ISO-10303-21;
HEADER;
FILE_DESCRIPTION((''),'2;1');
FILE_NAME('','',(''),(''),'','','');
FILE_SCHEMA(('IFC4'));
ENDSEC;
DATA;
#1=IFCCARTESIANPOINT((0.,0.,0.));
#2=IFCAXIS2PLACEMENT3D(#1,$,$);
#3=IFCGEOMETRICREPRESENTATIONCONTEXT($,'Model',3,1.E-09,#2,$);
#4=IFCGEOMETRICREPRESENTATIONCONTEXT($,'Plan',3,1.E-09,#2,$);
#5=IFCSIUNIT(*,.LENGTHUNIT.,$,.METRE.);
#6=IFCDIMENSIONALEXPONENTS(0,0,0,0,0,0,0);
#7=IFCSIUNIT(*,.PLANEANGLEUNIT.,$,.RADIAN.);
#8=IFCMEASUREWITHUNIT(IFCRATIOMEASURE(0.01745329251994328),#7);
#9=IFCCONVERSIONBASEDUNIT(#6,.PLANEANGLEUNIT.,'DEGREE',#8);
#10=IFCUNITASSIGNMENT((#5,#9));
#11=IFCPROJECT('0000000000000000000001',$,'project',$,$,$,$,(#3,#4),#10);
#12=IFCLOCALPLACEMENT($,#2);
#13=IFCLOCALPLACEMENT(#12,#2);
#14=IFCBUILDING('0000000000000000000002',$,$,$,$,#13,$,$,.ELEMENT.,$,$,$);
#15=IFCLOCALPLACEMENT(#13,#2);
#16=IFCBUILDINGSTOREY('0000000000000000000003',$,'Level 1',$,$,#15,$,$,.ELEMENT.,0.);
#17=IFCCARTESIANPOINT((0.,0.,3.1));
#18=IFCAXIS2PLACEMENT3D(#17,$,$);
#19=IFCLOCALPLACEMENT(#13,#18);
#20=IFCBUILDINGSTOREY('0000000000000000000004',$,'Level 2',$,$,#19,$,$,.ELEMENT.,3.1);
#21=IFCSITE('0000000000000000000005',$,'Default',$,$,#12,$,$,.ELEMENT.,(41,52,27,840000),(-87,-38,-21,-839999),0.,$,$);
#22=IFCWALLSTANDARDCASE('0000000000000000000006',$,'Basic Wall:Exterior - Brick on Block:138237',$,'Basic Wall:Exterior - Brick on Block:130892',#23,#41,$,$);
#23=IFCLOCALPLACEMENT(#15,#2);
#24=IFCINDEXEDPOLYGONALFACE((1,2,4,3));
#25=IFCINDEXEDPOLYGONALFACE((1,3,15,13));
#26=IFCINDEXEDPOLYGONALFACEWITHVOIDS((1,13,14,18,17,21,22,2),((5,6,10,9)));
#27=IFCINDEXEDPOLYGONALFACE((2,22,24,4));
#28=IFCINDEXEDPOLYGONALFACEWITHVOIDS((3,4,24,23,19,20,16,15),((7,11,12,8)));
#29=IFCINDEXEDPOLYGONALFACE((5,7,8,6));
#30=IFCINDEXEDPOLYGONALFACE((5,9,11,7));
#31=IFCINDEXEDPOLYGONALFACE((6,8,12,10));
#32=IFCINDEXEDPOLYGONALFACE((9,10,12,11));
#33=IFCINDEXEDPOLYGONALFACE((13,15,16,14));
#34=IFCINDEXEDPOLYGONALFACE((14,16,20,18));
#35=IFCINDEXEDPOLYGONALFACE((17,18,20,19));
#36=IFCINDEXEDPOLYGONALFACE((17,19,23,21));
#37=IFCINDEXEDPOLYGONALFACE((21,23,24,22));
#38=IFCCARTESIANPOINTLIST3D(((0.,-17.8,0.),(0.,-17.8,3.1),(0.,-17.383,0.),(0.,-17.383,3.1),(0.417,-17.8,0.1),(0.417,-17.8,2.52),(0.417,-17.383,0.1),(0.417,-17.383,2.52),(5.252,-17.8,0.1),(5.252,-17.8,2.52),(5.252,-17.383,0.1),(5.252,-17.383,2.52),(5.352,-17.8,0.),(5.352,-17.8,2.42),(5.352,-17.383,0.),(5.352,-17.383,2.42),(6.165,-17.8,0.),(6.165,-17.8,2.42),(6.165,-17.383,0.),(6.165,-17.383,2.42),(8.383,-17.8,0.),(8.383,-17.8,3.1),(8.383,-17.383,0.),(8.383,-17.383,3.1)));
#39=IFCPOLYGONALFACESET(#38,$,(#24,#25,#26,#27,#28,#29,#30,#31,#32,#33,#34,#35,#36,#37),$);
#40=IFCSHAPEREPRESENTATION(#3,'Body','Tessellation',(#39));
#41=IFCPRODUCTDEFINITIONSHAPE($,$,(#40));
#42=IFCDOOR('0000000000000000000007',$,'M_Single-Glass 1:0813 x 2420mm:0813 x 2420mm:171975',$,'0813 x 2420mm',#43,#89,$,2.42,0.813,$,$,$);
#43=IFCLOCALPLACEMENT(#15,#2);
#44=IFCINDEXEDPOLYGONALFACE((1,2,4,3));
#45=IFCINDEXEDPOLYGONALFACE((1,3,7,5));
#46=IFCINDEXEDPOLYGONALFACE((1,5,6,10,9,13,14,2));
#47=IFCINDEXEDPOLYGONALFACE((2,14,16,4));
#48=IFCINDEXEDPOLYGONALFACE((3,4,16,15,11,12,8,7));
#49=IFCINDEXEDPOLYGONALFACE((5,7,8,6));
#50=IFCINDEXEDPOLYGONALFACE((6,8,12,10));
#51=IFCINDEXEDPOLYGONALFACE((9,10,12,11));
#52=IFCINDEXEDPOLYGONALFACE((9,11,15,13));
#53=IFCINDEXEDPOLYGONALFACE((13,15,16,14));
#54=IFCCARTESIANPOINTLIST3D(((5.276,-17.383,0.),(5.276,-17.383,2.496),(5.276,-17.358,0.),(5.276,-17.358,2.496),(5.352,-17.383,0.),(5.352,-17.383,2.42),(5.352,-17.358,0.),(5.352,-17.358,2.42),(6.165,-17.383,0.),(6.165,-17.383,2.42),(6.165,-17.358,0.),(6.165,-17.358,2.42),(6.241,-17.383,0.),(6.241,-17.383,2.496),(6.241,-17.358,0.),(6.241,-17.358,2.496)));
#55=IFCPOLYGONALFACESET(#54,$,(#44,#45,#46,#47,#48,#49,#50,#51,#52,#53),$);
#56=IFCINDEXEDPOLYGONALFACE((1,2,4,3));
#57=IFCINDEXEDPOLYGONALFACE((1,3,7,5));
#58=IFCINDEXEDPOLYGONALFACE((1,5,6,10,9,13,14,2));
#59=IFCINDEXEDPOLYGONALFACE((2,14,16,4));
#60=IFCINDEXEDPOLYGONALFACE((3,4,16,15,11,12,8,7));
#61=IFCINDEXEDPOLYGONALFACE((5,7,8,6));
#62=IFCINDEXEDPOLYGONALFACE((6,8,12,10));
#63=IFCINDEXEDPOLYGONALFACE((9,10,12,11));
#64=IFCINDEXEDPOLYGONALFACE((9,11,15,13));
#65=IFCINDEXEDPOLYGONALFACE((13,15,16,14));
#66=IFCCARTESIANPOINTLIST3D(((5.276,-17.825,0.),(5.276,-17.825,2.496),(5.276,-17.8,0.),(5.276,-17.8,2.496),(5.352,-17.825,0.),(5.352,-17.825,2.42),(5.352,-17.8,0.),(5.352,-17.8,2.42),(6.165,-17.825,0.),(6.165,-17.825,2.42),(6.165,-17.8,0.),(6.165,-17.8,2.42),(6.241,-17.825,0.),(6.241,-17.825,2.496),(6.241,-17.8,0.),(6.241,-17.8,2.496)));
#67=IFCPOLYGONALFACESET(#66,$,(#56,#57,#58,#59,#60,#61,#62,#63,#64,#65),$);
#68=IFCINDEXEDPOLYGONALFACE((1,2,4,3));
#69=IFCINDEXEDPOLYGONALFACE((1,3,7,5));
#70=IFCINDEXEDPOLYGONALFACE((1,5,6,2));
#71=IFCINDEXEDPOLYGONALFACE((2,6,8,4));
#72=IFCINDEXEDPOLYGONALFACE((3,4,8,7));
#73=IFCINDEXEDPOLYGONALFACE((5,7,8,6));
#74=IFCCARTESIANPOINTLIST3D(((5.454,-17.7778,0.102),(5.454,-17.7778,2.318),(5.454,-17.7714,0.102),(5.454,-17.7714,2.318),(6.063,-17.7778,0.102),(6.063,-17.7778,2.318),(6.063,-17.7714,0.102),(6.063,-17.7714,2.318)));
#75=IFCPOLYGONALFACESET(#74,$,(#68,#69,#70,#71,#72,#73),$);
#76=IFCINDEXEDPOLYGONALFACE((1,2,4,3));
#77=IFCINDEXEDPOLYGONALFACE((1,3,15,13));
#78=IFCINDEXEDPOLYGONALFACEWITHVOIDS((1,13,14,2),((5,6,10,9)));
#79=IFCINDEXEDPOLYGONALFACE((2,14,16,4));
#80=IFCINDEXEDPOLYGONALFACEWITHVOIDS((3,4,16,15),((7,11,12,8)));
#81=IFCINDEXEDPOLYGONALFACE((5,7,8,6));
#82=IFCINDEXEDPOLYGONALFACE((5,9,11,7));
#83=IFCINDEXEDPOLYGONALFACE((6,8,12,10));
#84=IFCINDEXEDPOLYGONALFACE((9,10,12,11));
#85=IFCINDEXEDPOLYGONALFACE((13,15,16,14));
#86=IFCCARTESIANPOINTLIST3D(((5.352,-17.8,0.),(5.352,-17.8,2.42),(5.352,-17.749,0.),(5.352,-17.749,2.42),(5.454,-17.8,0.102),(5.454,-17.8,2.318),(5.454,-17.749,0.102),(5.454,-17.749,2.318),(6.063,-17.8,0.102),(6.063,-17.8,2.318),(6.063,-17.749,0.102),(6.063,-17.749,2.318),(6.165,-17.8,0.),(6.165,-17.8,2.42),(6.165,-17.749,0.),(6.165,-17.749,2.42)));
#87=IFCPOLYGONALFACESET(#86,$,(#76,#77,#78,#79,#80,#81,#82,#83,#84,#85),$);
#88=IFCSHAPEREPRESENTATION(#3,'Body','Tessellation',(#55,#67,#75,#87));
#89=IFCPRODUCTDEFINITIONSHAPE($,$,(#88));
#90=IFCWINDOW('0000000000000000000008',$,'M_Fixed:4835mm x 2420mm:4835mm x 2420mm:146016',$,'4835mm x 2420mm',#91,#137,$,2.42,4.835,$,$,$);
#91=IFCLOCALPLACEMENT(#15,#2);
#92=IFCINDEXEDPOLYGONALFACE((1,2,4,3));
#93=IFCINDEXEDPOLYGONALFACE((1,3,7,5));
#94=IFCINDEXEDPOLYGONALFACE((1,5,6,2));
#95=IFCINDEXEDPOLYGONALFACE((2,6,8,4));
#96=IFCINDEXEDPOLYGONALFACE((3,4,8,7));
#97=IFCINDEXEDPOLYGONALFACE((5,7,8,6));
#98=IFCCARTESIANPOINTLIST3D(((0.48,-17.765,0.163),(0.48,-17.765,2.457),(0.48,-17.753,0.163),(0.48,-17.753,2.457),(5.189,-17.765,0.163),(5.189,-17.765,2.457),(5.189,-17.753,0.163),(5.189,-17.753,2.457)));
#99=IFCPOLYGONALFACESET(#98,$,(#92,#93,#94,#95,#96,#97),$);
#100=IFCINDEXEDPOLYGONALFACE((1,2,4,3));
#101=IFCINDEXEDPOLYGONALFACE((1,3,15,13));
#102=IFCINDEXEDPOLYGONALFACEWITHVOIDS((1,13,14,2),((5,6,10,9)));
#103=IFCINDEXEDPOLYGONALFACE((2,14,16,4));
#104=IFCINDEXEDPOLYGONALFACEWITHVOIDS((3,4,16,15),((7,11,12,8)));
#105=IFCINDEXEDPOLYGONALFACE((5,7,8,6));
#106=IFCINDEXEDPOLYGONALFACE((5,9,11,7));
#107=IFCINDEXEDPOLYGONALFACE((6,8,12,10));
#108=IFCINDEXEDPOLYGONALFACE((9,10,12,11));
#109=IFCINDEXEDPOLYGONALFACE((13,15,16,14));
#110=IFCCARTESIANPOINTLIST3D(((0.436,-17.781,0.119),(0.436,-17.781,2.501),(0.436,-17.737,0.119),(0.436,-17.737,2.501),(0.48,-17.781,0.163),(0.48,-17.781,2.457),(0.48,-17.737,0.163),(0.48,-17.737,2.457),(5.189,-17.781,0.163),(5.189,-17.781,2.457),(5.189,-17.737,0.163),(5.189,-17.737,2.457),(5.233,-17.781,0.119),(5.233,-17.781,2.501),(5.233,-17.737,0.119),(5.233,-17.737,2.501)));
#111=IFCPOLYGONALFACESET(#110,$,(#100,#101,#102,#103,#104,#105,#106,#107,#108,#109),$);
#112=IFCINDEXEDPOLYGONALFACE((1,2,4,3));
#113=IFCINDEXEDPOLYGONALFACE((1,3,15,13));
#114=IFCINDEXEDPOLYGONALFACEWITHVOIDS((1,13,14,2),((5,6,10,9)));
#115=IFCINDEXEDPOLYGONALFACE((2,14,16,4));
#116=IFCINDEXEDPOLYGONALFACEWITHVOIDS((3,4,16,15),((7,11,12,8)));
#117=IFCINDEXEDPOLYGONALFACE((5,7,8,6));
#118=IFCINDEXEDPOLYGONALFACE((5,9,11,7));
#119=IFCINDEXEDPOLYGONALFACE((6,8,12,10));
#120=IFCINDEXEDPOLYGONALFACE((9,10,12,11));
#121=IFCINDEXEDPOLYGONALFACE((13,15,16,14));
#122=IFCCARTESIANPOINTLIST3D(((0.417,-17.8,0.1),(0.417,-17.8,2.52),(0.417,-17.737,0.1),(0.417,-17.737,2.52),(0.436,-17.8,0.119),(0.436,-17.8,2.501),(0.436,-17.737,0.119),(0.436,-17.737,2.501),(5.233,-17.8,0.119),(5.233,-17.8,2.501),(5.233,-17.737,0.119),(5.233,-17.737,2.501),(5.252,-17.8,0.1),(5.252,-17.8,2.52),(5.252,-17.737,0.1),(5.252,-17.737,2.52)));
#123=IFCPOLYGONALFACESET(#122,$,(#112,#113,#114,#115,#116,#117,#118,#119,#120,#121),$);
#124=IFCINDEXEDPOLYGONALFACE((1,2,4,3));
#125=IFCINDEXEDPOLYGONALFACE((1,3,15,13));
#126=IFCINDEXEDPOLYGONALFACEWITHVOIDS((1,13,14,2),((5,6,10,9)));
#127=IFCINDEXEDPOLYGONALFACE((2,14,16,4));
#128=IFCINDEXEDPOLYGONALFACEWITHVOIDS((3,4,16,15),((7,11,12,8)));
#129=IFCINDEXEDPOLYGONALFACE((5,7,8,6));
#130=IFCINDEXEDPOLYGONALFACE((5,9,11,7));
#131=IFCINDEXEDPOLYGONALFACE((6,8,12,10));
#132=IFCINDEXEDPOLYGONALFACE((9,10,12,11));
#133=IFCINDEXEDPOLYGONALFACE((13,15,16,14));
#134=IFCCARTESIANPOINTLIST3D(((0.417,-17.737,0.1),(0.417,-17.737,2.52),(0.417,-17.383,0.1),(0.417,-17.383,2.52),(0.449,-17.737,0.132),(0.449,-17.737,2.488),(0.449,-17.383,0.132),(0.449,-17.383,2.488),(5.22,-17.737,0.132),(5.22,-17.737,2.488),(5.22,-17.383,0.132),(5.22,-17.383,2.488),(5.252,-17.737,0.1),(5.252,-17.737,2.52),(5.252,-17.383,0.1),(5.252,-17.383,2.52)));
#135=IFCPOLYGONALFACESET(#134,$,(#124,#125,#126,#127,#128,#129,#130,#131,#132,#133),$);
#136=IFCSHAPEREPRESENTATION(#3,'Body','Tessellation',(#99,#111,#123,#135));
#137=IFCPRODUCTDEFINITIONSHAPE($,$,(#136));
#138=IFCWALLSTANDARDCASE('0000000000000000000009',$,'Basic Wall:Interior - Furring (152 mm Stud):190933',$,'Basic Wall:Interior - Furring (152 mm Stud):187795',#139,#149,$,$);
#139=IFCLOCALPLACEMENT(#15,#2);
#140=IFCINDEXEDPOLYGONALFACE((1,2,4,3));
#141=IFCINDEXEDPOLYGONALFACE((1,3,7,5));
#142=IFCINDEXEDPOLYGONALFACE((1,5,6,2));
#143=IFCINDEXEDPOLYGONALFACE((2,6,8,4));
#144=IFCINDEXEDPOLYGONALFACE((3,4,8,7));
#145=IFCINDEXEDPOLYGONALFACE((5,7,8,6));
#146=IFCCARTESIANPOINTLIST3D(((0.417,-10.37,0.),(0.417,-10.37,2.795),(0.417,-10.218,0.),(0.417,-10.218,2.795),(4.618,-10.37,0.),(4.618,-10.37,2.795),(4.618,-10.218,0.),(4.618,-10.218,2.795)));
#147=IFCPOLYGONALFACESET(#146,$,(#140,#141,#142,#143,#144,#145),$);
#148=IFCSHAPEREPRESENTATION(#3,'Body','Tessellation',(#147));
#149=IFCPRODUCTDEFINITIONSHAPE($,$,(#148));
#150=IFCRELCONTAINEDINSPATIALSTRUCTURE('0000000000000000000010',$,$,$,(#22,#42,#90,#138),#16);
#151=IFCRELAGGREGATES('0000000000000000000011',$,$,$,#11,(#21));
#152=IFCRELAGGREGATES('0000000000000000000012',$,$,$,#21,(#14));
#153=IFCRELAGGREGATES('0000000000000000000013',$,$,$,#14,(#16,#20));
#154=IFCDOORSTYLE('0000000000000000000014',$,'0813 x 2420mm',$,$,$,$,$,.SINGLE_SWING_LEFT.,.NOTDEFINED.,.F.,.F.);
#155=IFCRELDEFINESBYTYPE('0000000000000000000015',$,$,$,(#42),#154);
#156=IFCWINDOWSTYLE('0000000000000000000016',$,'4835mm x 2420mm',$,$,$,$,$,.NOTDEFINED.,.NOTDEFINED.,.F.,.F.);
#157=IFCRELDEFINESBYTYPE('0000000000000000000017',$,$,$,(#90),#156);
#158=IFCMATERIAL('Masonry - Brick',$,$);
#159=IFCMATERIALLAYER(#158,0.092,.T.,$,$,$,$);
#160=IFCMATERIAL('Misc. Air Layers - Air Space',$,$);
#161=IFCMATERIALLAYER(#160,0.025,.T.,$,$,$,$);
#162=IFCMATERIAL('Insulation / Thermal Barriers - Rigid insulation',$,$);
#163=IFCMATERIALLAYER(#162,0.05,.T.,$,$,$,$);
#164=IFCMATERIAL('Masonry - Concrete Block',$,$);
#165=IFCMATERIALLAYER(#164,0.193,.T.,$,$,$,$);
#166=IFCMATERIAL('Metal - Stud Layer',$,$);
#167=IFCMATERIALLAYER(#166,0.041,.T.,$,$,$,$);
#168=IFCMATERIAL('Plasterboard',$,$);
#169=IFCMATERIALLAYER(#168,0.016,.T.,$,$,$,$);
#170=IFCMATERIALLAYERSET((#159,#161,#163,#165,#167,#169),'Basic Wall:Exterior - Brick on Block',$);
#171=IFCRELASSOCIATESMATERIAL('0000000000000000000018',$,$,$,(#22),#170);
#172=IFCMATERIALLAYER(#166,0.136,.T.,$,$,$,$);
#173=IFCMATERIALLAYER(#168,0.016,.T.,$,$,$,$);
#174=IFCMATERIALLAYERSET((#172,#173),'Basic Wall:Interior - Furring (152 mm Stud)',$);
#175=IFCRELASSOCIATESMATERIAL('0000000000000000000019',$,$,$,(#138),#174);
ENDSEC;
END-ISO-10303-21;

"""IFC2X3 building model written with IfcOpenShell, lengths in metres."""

from ifc_helpers import new_model, entity, si_unit, converted_unit, frame, frame_2d, origin, origin_2d_with_axis, place, context, project, spatial, polyline, rectangle, outline, extrude, source, transform, mapped, material, layer, layer_set, layer_usage, type_object, type_shapes, element, fill, save


model = new_model("IFC2X3")

# Units and contexts
model_context = context("Model", 3, precision=1e-09, world=origin())
plan_context = context("Plan", 3, precision=1e-09, world=origin())
ifc_project = project(units=[si_unit("LENGTHUNIT", "METRE"), converted_unit("PLANEANGLEUNIT", "DEGREE", entity("IfcRatioMeasure", 0.01745329251994328), si_unit("PLANEANGLEUNIT", "RADIAN"), dimensions=[0, 0, 0, 0, 0, 0, 0])], contexts=[model_context, plan_context])

# Site, building, storey
site_placement = place(None, origin())
site = spatial("IfcSite", under=ifc_project, at=site_placement, Name="Default", CompositionType="ELEMENT", RefLatitude=(41, 52, 27, 840000), RefLongitude=(-87, -38, -21, -839999), RefElevation=0.0)
building_placement = place(site_placement, origin())
building = spatial("IfcBuilding", under=site, at=building_placement, CompositionType="ELEMENT")
storey_1_placement = place(building_placement, origin())
storey_1 = spatial("IfcBuildingStorey", under=building, at=storey_1_placement, Name="Level 1", CompositionType="ELEMENT", Elevation=0.0)

# Shared definitions
ifc_material_1 = material(Name="Masonry - Brick")
ifc_layer_1 = layer(ifc_material_1, 0.092, ventilated=True)
ifc_material_2 = material(Name="Misc. Air Layers - Air Space")
ifc_layer_2 = layer(ifc_material_2, 0.025, ventilated=True)
ifc_material_3 = material(Name="Insulation / Thermal Barriers - Rigid insulation")
ifc_layer_3 = layer(ifc_material_3, 0.05, ventilated=True)
ifc_material_4 = material(Name="Masonry - Concrete Block")
ifc_layer_4 = layer(ifc_material_4, 0.193, ventilated=True)
ifc_material_5 = material(Name="Metal - Stud Layer")
ifc_layer_5 = layer(ifc_material_5, 0.041, ventilated=True)
ifc_material_6 = material(Name="Plasterboard")
ifc_layer_6 = layer(ifc_material_6, 0.016, ventilated=True)
ifc_layer_set_1 = layer_set([ifc_layer_1, ifc_layer_2, ifc_layer_3, ifc_layer_4, ifc_layer_5, ifc_layer_6], Name="Basic Wall:Exterior - Brick on Block")
ifc_layer_usage_1 = layer_usage(ifc_layer_set_1, "AXIS2", "NEGATIVE", 0.2085)

# Shared definitions
storey_2_placement = place(building_placement, frame((0.0, 0.0, 3.1)))
storey_2 = spatial("IfcBuildingStorey", under=building, at=storey_2_placement, Name="Level 2", CompositionType="ELEMENT", Elevation=3.1)

# Shared definitions
ifc_layer_7 = layer(ifc_material_5, 0.136, ventilated=True)
ifc_layer_8 = layer(ifc_material_6, 0.016, ventilated=True)
ifc_layer_set_2 = layer_set([ifc_layer_7, ifc_layer_8], Name="Basic Wall:Interior - Furring (152 mm Stud)")

# Wall, openings, door, window
wall_1_placement = place(storey_1_placement, frame((8.383, -17.5915, 0.0), z_axis=(0.0, 0.0, 1.0), x_axis=(-1.0, 0.0, 0.0)))
wall_1 = element("IfcWallStandardCase", 1, at=wall_1_placement, inside=storey_1, material=ifc_layer_usage_1, Name="Basic Wall:Exterior - Brick on Block:138237", ObjectType="Basic Wall:Exterior - Brick on Block:130892", context=model_context, shape_type="SweptSolid", body=[
    extrude(rectangle(XDim=8.383, YDim=0.417, at=frame_2d((4.1915, 0.0), x_axis=(-1.0, 0.0))), origin(), (0.0, 0.0, 1.0), 3.1),
])
opening_1_placement = place(wall_1_placement, frame((3.131, -0.2085, 0.1)))
opening_1 = element("IfcOpeningElement", 2, at=opening_1_placement, cuts=wall_1, ObjectType="Opening", context=model_context, shape_type="SweptSolid", body=[
    extrude(rectangle(XDim=2.42, YDim=4.835, at=frame_2d((1.21, 2.4175), x_axis=(1.0, 0.0))), frame((0.0, 0.0, 0.0), z_axis=(0.0, 1.0, 0.0), x_axis=(0.0, 0.0, 1.0)), (0.0, 0.0, 1.0), 0.417),
])
opening_2_placement = place(wall_1_placement, frame((2.218, -0.2085, 0.0)))
opening_2 = element("IfcOpeningElement", 3, at=opening_2_placement, cuts=wall_1, ObjectType="Opening", context=model_context, shape_type="SweptSolid", body=[
    extrude(rectangle(XDim=0.813, YDim=2.42, at=frame_2d((1.21, 0.4065), x_axis=(0.0, -1.0))), frame((0.0, 0.0, 0.0), z_axis=(0.0, 1.0, 0.0), x_axis=(0.0, 0.0, 1.0)), (0.0, 0.0, 1.0), 0.417),
])
door_style_1 = type_object("IfcDoorStyle", Name="0813 x 2420mm", ConstructionType="NOTDEFINED", OperationType="SINGLE_SWING_LEFT", ParameterTakesPrecedence=False, Sizeable=False)
shared_shape_1 = source(origin(), model_context, "Body", "SweptSolid", [
    extrude(outline(polyline([(-0.4065, -1.191), (-0.4065, 1.229), (-0.4825, 1.229), (-0.4825, -1.267), (0.4825, -1.267), (0.4825, 1.229), (0.4065, 1.229), (0.4065, -1.191), (-0.4065, -1.191)])), frame((0.4065, 0.0, 1.229), z_axis=(0.0, 1.0, 0.0), x_axis=(1.0, 0.0, 0.0)), (0.0, 0.0, -1.0), 0.025),
    extrude(outline(polyline([(-0.4065, -1.191), (-0.4065, 1.229), (-0.4825, 1.229), (-0.4825, -1.267), (0.4825, -1.267), (0.4825, 1.229), (0.4065, 1.229), (0.4065, -1.191), (-0.4065, -1.191)])), frame((0.4065, 0.442, 1.229), z_axis=(0.0, 1.0, 0.0), x_axis=(1.0, 0.0, 0.0)), (0.0, 0.0, -1.0), 0.025),
    extrude(rectangle(XDim=0.609, YDim=0.0064, at=origin_2d_with_axis()), frame((0.4065, 0.3916, 0.102)), (0.0, 0.0, 1.0), 2.216),
    extrude(outline(polyline([(-1.21, -0.4065), (1.21, -0.4065), (1.21, 0.4065), (-1.21, 0.4065), (-1.21, -0.4065)]), holes=[polyline([(-1.108, 0.3045), (1.108, 0.3045), (1.108, -0.3045), (-1.108, -0.3045), (-1.108, 0.3045)])]), frame((0.4065, 0.417, 1.21), z_axis=(0.0, -1.0, 0.0), x_axis=(0.0, 0.0, -1.0)), (0.0, 0.0, 1.0), 0.051),
])
type_shapes(door_style_1, [shared_shape_1])
door_1_placement = place(opening_2_placement, origin())
door_1 = element("IfcDoor", 4, at=door_1_placement, inside=storey_1, type_object=door_style_1, Name="M_Single-Glass 1:0813 x 2420mm:0813 x 2420mm:171975", ObjectType="0813 x 2420mm", OverallHeight=2.42, OverallWidth=0.813, context=model_context, shape_type="MappedRepresentation", body=[
    mapped(shared_shape_1, transform((0.0, 0.0, 0.0), scale=1.0)),
])
fill(opening_2, door_1)
window_style_1 = type_object("IfcWindowStyle", Name="4835mm x 2420mm", ConstructionType="NOTDEFINED", OperationType="NOTDEFINED", ParameterTakesPrecedence=False, Sizeable=False)
shared_shape_2 = source(origin(), model_context, "Body", "SweptSolid", [
    extrude(rectangle(XDim=0.012, YDim=4.709, at=origin_2d_with_axis()), frame((2.4175, 0.376, 0.063), z_axis=(0.0, 0.0, 1.0), x_axis=(0.0, -1.0, 0.0)), (0.0, 0.0, 1.0), 2.294),
    extrude(outline(polyline([(-2.3985, -1.191), (2.3985, -1.191), (2.3985, 1.191), (-2.3985, 1.191), (-2.3985, -1.191)]), holes=[polyline([(-2.3545, -1.147), (-2.3545, 1.147), (2.3545, 1.147), (2.3545, -1.147), (-2.3545, -1.147)])]), frame((2.4175, 0.354, 1.21), z_axis=(0.0, 1.0, 0.0), x_axis=(1.0, 0.0, 0.0)), (0.0, 0.0, 1.0), 0.044),
    extrude(outline(polyline([(-2.4175, -1.21), (2.4175, -1.21), (2.4175, 1.21), (-2.4175, 1.21), (-2.4175, -1.21)]), holes=[polyline([(-2.3985, -1.191), (-2.3985, 1.191), (2.3985, 1.191), (2.3985, -1.191), (-2.3985, -1.191)])]), frame((2.4175, 0.354, 1.21), z_axis=(0.0, 1.0, 0.0), x_axis=(1.0, 0.0, 0.0)), (0.0, 0.0, 1.0), 0.063),
    extrude(outline(polyline([(-2.4175, -1.21), (2.4175, -1.21), (2.4175, 1.21), (-2.4175, 1.21), (-2.4175, -1.21)]), holes=[polyline([(-2.3855, -1.178), (-2.3855, 1.178), (2.3855, 1.178), (2.3855, -1.178), (-2.3855, -1.178)])]), frame((2.4175, 0.0, 1.21), z_axis=(0.0, 1.0, 0.0), x_axis=(1.0, 0.0, 0.0)), (0.0, 0.0, 1.0), 0.354),
])
type_shapes(window_style_1, [shared_shape_2])
window_1_placement = place(opening_1_placement, origin())
window_1 = element("IfcWindow", 5, at=window_1_placement, inside=storey_1, type_object=window_style_1, Name="M_Fixed:4835mm x 2420mm:4835mm x 2420mm:146016", ObjectType="4835mm x 2420mm", OverallHeight=2.42, OverallWidth=4.835, context=model_context, shape_type="MappedRepresentation", body=[
    mapped(shared_shape_2, transform((0.0, 0.0, 0.0), scale=1.0)),
])
fill(opening_1, window_1)

# Wall
ifc_layer_usage_2 = layer_usage(ifc_layer_set_2, "AXIS2", "NEGATIVE", 0.076)
wall_2_placement = place(storey_1_placement, frame((0.417, -10.294, 0.0)))
element("IfcWallStandardCase", 6, at=wall_2_placement, inside=storey_1, material=ifc_layer_usage_2, Name="Basic Wall:Interior - Furring (152 mm Stud):190933", ObjectType="Basic Wall:Interior - Furring (152 mm Stud):187795", context=model_context, shape_type="SweptSolid", body=[
    extrude(rectangle(XDim=4.201, YDim=0.152, at=frame_2d((2.1005, 0.0), x_axis=(-1.0, 0.0))), origin(), (0.0, 0.0, 1.0), 2.795),
])

save(model, "model.ifc")
